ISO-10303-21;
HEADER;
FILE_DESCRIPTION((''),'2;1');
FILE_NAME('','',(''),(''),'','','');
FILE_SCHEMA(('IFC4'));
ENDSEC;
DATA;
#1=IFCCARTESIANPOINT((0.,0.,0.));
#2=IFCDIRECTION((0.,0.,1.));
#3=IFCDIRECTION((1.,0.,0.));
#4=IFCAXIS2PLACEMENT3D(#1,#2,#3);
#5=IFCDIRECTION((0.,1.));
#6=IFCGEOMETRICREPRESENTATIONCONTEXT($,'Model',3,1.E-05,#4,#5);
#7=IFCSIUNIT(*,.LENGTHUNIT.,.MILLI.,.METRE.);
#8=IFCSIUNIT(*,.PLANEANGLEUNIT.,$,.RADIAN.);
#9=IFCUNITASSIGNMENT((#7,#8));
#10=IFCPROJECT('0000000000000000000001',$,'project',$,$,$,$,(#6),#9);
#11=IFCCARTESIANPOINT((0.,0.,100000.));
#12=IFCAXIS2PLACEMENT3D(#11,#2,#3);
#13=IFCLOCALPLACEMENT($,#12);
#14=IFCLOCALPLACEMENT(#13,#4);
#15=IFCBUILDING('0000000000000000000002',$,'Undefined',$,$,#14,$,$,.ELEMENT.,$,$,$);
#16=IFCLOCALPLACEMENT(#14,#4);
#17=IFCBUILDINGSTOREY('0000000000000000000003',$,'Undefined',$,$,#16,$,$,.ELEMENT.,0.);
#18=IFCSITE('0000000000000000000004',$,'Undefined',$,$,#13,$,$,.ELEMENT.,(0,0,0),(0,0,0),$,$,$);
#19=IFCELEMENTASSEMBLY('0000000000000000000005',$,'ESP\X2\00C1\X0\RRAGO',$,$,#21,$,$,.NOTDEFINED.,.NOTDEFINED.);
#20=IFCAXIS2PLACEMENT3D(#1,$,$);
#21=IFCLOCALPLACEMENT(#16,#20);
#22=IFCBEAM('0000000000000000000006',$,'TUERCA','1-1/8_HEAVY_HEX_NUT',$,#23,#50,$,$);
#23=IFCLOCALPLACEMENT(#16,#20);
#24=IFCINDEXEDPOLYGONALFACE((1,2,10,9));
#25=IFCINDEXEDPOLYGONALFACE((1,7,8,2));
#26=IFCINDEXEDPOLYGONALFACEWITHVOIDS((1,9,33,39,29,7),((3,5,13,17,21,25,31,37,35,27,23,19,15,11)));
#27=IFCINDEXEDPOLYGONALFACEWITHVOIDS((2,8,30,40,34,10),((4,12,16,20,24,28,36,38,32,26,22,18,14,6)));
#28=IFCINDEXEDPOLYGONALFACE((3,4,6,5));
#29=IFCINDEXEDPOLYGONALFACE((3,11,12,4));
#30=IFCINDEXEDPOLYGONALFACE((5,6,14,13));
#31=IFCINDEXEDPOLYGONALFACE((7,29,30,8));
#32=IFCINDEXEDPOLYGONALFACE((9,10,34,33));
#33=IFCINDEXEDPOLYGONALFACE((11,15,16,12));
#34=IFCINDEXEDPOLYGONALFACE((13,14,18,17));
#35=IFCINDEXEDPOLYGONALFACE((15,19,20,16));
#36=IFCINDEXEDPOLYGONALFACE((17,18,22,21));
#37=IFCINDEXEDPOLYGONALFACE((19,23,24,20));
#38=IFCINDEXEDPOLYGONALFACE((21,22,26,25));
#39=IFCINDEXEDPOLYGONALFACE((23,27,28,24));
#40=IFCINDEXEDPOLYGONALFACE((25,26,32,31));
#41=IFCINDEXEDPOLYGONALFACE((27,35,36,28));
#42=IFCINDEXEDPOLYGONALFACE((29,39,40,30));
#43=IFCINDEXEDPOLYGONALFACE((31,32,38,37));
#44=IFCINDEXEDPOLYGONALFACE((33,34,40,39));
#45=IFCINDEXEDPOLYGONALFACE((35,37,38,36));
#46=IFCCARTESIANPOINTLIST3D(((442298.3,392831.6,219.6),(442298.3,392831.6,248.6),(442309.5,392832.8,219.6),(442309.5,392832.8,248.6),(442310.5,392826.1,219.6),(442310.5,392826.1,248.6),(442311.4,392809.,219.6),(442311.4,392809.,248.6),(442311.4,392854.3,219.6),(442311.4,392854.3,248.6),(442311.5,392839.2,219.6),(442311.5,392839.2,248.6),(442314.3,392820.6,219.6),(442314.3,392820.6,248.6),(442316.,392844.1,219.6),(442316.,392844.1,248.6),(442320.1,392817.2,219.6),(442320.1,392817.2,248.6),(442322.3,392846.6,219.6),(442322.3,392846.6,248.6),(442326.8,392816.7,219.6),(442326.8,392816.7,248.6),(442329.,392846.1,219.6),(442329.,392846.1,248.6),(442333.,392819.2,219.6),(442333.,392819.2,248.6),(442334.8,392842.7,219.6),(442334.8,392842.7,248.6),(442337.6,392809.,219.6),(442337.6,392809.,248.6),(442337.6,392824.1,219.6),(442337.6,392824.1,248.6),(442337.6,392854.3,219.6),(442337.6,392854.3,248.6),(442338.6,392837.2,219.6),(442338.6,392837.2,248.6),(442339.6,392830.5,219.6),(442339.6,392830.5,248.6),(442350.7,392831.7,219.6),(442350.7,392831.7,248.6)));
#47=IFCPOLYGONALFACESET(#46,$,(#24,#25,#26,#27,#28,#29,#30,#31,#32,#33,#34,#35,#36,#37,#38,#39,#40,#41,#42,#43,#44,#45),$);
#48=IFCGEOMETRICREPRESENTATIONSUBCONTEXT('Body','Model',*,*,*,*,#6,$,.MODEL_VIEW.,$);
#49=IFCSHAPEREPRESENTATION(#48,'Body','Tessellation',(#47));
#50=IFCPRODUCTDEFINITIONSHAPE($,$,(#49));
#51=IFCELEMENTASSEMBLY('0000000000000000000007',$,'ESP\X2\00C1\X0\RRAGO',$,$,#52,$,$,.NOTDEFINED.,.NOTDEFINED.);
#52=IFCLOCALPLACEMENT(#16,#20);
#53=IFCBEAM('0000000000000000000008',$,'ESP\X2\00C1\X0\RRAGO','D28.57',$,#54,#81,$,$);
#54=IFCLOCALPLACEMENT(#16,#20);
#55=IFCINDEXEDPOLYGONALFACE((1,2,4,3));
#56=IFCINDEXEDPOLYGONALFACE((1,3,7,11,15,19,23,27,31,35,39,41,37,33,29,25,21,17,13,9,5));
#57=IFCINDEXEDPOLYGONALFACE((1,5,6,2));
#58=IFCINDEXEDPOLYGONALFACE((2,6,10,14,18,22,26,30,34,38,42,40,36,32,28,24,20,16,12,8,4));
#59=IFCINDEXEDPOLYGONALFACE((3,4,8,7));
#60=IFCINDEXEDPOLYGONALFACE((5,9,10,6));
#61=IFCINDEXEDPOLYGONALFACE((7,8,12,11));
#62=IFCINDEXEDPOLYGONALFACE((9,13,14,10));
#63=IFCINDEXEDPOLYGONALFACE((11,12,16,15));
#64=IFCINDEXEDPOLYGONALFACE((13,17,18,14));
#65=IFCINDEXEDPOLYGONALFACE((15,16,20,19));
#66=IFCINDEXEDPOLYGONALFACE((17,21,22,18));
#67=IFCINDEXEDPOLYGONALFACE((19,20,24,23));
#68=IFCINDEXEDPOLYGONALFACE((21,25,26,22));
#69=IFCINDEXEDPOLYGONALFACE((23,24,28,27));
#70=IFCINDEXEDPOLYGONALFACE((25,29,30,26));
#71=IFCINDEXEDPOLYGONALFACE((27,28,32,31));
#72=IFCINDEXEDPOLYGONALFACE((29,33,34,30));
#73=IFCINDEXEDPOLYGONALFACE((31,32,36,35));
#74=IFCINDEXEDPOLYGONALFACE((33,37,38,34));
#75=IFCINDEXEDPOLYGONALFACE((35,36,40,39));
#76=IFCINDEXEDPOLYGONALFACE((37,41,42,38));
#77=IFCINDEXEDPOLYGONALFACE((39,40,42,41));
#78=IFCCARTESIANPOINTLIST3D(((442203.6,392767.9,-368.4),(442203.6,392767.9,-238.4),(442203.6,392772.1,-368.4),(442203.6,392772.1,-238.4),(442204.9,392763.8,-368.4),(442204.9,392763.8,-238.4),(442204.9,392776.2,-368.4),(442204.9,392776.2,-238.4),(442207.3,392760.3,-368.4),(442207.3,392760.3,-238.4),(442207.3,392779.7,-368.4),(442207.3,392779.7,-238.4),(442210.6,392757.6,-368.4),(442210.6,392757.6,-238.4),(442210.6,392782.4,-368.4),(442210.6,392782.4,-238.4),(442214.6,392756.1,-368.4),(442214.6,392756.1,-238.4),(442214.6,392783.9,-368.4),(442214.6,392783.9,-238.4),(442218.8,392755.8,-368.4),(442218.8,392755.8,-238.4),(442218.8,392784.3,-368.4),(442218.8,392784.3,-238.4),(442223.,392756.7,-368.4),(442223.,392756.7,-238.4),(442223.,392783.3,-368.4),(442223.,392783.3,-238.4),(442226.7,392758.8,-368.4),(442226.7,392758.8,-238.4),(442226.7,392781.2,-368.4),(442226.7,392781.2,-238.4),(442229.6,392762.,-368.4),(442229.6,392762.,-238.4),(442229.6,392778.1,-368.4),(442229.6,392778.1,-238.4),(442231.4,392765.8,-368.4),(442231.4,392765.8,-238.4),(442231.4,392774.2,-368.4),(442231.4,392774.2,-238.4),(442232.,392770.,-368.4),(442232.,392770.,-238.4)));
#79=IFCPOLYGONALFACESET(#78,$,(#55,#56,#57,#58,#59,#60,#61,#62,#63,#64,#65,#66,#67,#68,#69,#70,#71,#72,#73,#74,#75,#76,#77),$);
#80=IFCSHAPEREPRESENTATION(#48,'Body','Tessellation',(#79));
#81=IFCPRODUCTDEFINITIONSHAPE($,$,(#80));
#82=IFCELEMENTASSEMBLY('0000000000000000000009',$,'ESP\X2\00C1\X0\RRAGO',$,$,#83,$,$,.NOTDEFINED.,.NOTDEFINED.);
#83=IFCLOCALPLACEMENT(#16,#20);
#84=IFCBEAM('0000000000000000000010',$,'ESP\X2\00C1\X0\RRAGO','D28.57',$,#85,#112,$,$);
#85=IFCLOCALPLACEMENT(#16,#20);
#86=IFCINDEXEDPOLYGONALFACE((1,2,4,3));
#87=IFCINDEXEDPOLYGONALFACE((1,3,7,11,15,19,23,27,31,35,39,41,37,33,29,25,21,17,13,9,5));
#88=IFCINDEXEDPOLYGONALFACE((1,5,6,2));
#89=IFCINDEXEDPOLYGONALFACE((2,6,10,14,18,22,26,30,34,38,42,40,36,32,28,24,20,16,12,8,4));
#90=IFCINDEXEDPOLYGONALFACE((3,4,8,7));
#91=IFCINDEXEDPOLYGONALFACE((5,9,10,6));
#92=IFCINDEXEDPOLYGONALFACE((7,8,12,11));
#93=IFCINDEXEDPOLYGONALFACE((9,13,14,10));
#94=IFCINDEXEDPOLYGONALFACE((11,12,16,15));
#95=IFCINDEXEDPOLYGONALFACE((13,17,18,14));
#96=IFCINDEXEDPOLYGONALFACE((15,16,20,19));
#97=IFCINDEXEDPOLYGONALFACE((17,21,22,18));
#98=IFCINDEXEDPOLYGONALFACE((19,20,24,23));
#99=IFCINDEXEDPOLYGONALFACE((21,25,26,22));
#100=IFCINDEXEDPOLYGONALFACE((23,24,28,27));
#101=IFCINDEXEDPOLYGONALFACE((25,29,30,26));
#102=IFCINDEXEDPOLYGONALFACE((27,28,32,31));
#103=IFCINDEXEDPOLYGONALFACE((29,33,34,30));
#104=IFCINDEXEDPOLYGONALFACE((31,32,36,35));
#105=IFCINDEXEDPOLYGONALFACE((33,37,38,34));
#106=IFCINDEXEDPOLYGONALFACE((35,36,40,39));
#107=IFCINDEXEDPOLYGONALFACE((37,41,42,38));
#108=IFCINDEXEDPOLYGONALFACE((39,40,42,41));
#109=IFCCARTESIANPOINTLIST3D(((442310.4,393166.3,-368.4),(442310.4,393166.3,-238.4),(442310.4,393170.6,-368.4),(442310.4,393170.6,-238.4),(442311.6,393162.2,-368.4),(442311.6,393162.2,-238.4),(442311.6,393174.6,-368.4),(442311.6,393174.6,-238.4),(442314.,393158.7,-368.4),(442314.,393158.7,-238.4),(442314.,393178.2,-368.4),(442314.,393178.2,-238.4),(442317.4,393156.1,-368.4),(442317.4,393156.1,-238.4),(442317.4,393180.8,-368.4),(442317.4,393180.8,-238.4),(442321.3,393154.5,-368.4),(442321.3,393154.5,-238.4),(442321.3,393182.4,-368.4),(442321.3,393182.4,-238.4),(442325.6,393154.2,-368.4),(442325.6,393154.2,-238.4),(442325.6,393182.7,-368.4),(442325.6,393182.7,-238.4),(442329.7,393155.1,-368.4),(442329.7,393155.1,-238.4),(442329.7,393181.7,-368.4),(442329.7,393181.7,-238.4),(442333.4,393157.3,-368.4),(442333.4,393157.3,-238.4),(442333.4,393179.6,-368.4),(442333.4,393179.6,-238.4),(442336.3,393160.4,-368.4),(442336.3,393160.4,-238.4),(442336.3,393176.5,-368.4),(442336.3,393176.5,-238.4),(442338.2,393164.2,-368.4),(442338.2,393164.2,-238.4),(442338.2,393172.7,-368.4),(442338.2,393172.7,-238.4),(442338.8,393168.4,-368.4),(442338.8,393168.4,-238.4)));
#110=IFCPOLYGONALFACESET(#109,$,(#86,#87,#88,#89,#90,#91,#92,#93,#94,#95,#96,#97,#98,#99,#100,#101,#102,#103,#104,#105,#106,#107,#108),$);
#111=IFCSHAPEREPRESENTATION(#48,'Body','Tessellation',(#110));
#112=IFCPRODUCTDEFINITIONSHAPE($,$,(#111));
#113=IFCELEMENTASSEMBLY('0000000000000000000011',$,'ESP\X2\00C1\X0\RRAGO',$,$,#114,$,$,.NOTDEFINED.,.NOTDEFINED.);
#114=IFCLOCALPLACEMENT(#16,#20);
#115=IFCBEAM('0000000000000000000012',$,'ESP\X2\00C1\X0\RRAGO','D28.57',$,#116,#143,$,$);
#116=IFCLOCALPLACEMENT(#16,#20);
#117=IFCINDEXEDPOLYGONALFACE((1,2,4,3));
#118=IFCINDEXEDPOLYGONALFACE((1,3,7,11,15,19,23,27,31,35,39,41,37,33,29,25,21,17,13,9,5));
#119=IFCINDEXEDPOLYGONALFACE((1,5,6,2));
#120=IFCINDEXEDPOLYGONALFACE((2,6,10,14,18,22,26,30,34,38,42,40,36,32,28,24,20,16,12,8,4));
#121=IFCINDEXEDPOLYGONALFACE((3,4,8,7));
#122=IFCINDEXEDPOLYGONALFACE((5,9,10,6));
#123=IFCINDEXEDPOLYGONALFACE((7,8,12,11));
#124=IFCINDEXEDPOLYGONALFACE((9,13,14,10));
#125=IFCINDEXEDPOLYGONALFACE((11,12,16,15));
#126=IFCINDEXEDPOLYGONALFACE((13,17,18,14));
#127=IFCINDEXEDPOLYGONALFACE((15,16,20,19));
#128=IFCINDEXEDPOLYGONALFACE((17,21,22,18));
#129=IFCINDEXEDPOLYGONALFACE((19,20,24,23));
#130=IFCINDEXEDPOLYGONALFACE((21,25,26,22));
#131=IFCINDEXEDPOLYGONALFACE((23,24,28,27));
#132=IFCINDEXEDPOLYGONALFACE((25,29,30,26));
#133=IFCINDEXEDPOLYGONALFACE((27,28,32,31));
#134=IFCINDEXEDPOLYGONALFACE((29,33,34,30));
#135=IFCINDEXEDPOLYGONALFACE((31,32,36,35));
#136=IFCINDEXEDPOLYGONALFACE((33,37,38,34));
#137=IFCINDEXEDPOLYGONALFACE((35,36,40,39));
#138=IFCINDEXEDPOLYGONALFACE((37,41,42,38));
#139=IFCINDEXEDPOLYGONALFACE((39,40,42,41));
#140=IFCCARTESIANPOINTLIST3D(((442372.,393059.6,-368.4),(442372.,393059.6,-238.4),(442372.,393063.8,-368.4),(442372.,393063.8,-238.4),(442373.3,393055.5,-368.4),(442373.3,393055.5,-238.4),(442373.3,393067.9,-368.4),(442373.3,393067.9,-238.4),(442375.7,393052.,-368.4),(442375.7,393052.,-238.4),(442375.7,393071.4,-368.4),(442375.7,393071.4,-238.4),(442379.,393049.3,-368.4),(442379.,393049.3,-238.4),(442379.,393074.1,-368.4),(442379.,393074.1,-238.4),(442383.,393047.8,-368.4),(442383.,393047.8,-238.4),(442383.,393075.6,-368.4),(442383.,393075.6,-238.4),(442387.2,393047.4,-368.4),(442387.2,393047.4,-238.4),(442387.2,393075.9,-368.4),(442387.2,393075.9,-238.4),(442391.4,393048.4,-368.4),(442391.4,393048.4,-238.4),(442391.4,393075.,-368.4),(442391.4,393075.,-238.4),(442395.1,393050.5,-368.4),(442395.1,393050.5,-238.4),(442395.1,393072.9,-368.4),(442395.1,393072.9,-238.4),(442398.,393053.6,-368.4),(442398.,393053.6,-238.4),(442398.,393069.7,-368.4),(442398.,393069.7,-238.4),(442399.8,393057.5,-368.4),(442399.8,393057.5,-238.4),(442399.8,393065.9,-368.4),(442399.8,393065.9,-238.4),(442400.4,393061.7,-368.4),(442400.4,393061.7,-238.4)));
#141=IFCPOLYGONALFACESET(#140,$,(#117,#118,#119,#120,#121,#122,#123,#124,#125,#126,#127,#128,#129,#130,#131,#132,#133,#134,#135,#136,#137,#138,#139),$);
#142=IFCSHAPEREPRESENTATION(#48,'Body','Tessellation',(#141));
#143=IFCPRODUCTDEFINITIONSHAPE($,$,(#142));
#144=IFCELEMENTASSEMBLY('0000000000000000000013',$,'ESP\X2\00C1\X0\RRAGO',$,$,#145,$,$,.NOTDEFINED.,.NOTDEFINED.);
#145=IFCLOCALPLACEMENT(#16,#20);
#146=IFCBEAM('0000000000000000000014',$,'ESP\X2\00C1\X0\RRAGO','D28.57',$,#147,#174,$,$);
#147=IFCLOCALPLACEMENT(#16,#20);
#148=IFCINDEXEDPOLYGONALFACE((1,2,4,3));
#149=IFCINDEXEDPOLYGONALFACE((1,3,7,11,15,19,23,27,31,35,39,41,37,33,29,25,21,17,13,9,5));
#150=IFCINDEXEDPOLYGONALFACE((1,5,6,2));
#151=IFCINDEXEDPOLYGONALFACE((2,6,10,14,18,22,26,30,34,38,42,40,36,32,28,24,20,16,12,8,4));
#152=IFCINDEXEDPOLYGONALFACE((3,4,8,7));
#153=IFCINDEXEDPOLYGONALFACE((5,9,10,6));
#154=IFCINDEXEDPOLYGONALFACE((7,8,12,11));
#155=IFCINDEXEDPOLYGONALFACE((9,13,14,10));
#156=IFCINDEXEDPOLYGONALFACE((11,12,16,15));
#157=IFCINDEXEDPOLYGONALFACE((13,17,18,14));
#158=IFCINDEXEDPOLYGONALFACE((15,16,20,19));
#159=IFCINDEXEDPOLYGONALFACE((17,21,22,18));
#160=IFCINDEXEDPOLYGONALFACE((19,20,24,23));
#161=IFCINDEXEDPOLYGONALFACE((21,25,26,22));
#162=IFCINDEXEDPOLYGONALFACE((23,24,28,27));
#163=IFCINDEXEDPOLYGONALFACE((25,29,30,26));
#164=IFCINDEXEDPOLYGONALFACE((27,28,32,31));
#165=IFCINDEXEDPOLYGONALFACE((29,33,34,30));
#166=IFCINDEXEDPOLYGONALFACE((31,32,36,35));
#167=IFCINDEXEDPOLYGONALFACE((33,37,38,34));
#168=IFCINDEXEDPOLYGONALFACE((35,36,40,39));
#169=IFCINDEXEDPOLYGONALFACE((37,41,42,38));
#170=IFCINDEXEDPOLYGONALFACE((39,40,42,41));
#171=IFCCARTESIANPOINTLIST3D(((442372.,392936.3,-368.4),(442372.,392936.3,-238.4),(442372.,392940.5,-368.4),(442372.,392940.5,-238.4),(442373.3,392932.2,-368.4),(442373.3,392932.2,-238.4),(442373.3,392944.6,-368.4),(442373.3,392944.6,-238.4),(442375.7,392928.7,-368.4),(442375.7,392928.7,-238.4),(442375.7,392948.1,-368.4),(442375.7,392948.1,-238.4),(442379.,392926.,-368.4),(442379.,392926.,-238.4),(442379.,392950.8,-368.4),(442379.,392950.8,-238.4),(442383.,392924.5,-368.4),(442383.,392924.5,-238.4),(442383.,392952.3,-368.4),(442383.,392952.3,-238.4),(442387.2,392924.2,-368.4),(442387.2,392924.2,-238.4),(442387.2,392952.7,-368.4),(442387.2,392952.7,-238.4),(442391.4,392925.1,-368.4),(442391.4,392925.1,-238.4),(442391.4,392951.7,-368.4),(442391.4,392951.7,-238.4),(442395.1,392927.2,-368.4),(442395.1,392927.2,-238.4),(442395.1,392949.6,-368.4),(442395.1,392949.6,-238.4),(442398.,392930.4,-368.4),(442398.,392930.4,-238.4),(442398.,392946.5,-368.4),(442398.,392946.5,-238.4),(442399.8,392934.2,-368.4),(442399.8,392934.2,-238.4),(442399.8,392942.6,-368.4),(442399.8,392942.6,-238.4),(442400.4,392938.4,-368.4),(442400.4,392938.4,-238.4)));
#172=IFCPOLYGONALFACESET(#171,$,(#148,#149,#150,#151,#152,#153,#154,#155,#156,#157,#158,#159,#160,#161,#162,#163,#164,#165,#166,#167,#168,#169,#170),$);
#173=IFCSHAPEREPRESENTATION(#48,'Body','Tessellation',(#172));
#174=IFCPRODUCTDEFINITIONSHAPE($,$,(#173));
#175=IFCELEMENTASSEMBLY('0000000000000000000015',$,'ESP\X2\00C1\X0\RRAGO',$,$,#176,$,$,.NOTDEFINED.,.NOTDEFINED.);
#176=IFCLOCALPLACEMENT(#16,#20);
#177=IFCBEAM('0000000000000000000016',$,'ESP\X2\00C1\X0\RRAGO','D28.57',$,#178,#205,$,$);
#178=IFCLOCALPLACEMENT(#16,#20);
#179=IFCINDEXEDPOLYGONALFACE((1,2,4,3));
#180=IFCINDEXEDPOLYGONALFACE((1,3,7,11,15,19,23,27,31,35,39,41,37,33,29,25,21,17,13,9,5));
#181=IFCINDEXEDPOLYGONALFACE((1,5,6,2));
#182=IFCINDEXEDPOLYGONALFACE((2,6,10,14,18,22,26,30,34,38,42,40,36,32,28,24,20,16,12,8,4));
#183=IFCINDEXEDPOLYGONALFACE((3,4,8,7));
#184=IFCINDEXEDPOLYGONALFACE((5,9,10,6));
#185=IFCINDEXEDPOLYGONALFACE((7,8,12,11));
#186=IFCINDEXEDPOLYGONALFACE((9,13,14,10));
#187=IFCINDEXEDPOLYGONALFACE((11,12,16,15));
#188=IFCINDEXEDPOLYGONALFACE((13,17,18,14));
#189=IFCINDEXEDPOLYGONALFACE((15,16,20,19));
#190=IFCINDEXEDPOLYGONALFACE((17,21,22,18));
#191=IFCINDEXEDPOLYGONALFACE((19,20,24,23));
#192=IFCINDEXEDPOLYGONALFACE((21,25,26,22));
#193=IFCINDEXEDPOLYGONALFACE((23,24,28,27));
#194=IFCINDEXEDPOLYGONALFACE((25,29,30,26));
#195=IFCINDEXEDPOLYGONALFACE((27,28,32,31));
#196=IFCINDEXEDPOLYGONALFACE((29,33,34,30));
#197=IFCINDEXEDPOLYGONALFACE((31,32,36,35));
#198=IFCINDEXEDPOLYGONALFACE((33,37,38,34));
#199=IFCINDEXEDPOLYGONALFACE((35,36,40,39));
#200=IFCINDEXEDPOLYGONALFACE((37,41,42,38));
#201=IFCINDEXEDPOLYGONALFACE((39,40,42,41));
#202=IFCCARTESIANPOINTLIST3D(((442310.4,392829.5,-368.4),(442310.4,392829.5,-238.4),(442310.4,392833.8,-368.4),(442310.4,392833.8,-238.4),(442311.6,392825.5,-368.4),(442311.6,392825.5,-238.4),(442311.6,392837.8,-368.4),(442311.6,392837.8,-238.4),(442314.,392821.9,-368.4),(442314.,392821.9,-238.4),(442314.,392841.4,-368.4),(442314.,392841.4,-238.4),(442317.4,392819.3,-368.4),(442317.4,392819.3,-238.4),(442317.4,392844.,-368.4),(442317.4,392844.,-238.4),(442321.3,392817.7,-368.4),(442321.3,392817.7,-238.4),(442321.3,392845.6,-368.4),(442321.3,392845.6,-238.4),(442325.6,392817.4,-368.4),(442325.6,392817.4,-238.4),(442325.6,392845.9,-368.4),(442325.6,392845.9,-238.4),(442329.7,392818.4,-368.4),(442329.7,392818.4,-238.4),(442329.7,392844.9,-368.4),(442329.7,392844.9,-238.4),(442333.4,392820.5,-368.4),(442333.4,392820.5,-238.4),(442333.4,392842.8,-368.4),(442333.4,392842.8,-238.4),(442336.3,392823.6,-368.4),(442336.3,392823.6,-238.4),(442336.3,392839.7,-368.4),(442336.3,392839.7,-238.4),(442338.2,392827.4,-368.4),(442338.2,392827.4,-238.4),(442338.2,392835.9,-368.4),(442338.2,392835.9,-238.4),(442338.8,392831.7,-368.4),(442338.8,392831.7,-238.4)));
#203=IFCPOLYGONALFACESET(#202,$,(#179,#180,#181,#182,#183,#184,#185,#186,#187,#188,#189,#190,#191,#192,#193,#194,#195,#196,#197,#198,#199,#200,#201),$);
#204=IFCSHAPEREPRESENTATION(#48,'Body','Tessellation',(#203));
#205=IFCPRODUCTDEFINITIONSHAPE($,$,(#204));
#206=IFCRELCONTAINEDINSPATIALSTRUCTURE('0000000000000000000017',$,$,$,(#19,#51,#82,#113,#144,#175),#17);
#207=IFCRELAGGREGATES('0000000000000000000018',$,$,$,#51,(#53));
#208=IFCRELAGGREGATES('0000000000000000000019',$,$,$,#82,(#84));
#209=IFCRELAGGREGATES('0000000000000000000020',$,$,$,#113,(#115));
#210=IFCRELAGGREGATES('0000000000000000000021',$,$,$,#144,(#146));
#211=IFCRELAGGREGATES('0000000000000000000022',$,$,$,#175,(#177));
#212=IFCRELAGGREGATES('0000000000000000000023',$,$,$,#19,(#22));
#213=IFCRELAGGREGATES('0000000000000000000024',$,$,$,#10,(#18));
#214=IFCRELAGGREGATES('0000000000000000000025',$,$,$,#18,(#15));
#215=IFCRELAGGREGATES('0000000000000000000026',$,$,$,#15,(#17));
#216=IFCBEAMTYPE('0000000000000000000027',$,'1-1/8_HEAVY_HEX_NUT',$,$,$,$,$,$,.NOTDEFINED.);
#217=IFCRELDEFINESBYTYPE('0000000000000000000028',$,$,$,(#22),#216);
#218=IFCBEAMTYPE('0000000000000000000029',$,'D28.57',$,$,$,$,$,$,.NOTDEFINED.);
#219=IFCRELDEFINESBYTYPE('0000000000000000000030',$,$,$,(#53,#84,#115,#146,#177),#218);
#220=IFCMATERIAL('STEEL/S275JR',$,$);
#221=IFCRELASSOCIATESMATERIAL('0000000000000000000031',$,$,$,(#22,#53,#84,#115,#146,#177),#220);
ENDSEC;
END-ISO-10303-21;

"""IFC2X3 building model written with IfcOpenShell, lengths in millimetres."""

from ifc_helpers import new_model, si_unit, direction, frame, origin_with_axes, origin_2d_with_axis, place, context, subcontext, project, spatial, polyline, circle, outline, extrude, material, type_object, element, aggregate, save


model = new_model("IFC2X3")

# Units and contexts
model_context = context("Model", 3, precision=1e-05, world=origin_with_axes(), true_north=direction((0.0, 1.0)))
body_context = subcontext(model_context, "Body", "Model", "MODEL_VIEW")
ifc_project = project(units=[si_unit("LENGTHUNIT", "METRE", prefix="MILLI"), si_unit("PLANEANGLEUNIT", "RADIAN")], contexts=[model_context])

# Site, building, storey
site_placement = place(None, frame((0.0, 0.0, 100000.0), z_axis=(0.0, 0.0, 1.0), x_axis=(1.0, 0.0, 0.0)))
site = spatial("IfcSite", under=ifc_project, at=site_placement, Name="Undefined", CompositionType="ELEMENT", RefLatitude=(0, 0, 0), RefLongitude=(0, 0, 0))
building_placement = place(site_placement, origin_with_axes())
building = spatial("IfcBuilding", under=site, at=building_placement, Name="Undefined", CompositionType="ELEMENT")
storey_placement = place(building_placement, origin_with_axes())
storey = spatial("IfcBuildingStorey", under=building, at=storey_placement, Name="Undefined", CompositionType="ELEMENT", Elevation=0.0)

# Shared definitions
ifc_material = material(Name="STEEL/S275JR")
beam_type_1 = type_object("IfcBeamType", Name="1-1/8_HEAVY_HEX_NUT", PredefinedType="NOTDEFINED")

# Element assembly, beam
assembly_1_placement = place(storey_placement, origin_with_axes())
assembly_1 = element("IfcElementAssembly", 1, at=assembly_1_placement, inside=storey, Name="ESPÁRRAGO", AssemblyPlace="NOTDEFINED", PredefinedType="NOTDEFINED")
beam_1_placement = place(assembly_1_placement, frame((442324.5, 392831.7, 248.6), z_axis=(0.866025, -0.5, 0.0), x_axis=(0.0, 0.0, -1.0)))
beam_1 = element("IfcBeam", 2, at=beam_1_placement, type_object=beam_type_1, material=ifc_material, Name="TUERCA", Description="1-1/8_HEAVY_HEX_NUT", context=body_context, shape_type="SweptSolid", body=[
    extrude(outline(polyline([(-13.1, -22.7), (-26.2, 0.0), (-13.1, 22.7), (13.1, 22.7), (26.2, 0.0), (13.1, -22.7), (-13.1, -22.7)]), holes=[polyline([(6.5, 13.6), (0.0, 15.1), (-6.5, 13.6), (-11.8, 9.4), (-14.7, 3.4), (-14.7, -3.4), (-11.8, -9.4), (-6.5, -13.6), (0.0, -15.1), (6.5, -13.6), (11.8, -9.4), (14.7, -3.4), (14.7, 3.4), (11.8, 9.4), (6.5, 13.6)])]), frame((29.0, 0.0, 0.0), z_axis=(-1.0, 0.0, 0.0), x_axis=(0.0, -1.0, 0.0)), (0.0, 0.0, 1.0), 29.0),
])

# Element assemblies, beams
assembly_2_placement = place(storey_placement, origin_with_axes())
assembly_2 = element("IfcElementAssembly", 3, at=assembly_2_placement, inside=storey, Name="ESPÁRRAGO", AssemblyPlace="NOTDEFINED", PredefinedType="NOTDEFINED")
beam_type_2 = type_object("IfcBeamType", Name="D28.57", PredefinedType="NOTDEFINED")
beam_2_placement = place(assembly_2_placement, frame((442217.8, 392770.0, -238.4), z_axis=(0.866025, -0.5, 0.0), x_axis=(0.0, 0.0, -1.0)))
beam_2 = element("IfcBeam", 4, at=beam_2_placement, type_object=beam_type_2, material=ifc_material, Name="ESPÁRRAGO", Description="D28.57", context=body_context, shape_type="SweptSolid", body=[
    extrude(circle(Radius=14.3, at=origin_2d_with_axis()), frame((130.0, 0.0, 0.0), z_axis=(-1.0, 0.0, 0.0), x_axis=(0.0, -1.0, 0.0)), (0.0, 0.0, 1.0), 130.0),
])
aggregate(assembly_2, [beam_2])
assembly_3_placement = place(storey_placement, origin_with_axes())
assembly_3 = element("IfcElementAssembly", 5, at=assembly_3_placement, inside=storey, Name="ESPÁRRAGO", AssemblyPlace="NOTDEFINED", PredefinedType="NOTDEFINED")
beam_3_placement = place(assembly_3_placement, frame((442324.5, 393168.4, -238.4), z_axis=(0.866025, -0.5, 0.0), x_axis=(0.0, 0.0, -1.0)))
beam_3 = element("IfcBeam", 6, at=beam_3_placement, type_object=beam_type_2, material=ifc_material, Name="ESPÁRRAGO", Description="D28.57", context=body_context, shape_type="SweptSolid", body=[
    extrude(circle(Radius=14.3, at=origin_2d_with_axis()), frame((130.0, 0.0, 0.0), z_axis=(-1.0, 0.0, 0.0), x_axis=(0.0, -1.0, 0.0)), (0.0, 0.0, 1.0), 130.0),
])
aggregate(assembly_3, [beam_3])
assembly_4_placement = place(storey_placement, origin_with_axes())
assembly_4 = element("IfcElementAssembly", 7, at=assembly_4_placement, inside=storey, Name="ESPÁRRAGO", AssemblyPlace="NOTDEFINED", PredefinedType="NOTDEFINED")
beam_4_placement = place(assembly_4_placement, frame((442386.2, 393061.7, -238.4), z_axis=(0.866025, -0.5, 0.0), x_axis=(0.0, 0.0, -1.0)))
beam_4 = element("IfcBeam", 8, at=beam_4_placement, type_object=beam_type_2, material=ifc_material, Name="ESPÁRRAGO", Description="D28.57", context=body_context, shape_type="SweptSolid", body=[
    extrude(circle(Radius=14.3, at=origin_2d_with_axis()), frame((130.0, 0.0, 0.0), z_axis=(-1.0, 0.0, 0.0), x_axis=(0.0, -1.0, 0.0)), (0.0, 0.0, 1.0), 130.0),
])
aggregate(assembly_4, [beam_4])
assembly_5_placement = place(storey_placement, origin_with_axes())
assembly_5 = element("IfcElementAssembly", 9, at=assembly_5_placement, inside=storey, Name="ESPÁRRAGO", AssemblyPlace="NOTDEFINED", PredefinedType="NOTDEFINED")
beam_5_placement = place(assembly_5_placement, frame((442386.2, 392938.4, -238.4), z_axis=(0.866025, -0.5, 0.0), x_axis=(0.0, 0.0, -1.0)))
beam_5 = element("IfcBeam", 10, at=beam_5_placement, type_object=beam_type_2, material=ifc_material, Name="ESPÁRRAGO", Description="D28.57", context=body_context, shape_type="SweptSolid", body=[
    extrude(circle(Radius=14.3, at=origin_2d_with_axis()), frame((130.0, 0.0, 0.0), z_axis=(-1.0, 0.0, 0.0), x_axis=(0.0, -1.0, 0.0)), (0.0, 0.0, 1.0), 130.0),
])
aggregate(assembly_5, [beam_5])
assembly_6_placement = place(storey_placement, origin_with_axes())
assembly_6 = element("IfcElementAssembly", 11, at=assembly_6_placement, inside=storey, Name="ESPÁRRAGO", AssemblyPlace="NOTDEFINED", PredefinedType="NOTDEFINED")
beam_6_placement = place(assembly_6_placement, frame((442324.5, 392831.7, -238.4), z_axis=(0.866025, -0.5, 0.0), x_axis=(0.0, 0.0, -1.0)))
beam_6 = element("IfcBeam", 12, at=beam_6_placement, type_object=beam_type_2, material=ifc_material, Name="ESPÁRRAGO", Description="D28.57", context=body_context, shape_type="SweptSolid", body=[
    extrude(circle(Radius=14.3, at=origin_2d_with_axis()), frame((130.0, 0.0, 0.0), z_axis=(-1.0, 0.0, 0.0), x_axis=(0.0, -1.0, 0.0)), (0.0, 0.0, 1.0), 130.0),
])
aggregate(assembly_6, [beam_6])

aggregate(assembly_1, [beam_1])

save(model, "model.ifc")
